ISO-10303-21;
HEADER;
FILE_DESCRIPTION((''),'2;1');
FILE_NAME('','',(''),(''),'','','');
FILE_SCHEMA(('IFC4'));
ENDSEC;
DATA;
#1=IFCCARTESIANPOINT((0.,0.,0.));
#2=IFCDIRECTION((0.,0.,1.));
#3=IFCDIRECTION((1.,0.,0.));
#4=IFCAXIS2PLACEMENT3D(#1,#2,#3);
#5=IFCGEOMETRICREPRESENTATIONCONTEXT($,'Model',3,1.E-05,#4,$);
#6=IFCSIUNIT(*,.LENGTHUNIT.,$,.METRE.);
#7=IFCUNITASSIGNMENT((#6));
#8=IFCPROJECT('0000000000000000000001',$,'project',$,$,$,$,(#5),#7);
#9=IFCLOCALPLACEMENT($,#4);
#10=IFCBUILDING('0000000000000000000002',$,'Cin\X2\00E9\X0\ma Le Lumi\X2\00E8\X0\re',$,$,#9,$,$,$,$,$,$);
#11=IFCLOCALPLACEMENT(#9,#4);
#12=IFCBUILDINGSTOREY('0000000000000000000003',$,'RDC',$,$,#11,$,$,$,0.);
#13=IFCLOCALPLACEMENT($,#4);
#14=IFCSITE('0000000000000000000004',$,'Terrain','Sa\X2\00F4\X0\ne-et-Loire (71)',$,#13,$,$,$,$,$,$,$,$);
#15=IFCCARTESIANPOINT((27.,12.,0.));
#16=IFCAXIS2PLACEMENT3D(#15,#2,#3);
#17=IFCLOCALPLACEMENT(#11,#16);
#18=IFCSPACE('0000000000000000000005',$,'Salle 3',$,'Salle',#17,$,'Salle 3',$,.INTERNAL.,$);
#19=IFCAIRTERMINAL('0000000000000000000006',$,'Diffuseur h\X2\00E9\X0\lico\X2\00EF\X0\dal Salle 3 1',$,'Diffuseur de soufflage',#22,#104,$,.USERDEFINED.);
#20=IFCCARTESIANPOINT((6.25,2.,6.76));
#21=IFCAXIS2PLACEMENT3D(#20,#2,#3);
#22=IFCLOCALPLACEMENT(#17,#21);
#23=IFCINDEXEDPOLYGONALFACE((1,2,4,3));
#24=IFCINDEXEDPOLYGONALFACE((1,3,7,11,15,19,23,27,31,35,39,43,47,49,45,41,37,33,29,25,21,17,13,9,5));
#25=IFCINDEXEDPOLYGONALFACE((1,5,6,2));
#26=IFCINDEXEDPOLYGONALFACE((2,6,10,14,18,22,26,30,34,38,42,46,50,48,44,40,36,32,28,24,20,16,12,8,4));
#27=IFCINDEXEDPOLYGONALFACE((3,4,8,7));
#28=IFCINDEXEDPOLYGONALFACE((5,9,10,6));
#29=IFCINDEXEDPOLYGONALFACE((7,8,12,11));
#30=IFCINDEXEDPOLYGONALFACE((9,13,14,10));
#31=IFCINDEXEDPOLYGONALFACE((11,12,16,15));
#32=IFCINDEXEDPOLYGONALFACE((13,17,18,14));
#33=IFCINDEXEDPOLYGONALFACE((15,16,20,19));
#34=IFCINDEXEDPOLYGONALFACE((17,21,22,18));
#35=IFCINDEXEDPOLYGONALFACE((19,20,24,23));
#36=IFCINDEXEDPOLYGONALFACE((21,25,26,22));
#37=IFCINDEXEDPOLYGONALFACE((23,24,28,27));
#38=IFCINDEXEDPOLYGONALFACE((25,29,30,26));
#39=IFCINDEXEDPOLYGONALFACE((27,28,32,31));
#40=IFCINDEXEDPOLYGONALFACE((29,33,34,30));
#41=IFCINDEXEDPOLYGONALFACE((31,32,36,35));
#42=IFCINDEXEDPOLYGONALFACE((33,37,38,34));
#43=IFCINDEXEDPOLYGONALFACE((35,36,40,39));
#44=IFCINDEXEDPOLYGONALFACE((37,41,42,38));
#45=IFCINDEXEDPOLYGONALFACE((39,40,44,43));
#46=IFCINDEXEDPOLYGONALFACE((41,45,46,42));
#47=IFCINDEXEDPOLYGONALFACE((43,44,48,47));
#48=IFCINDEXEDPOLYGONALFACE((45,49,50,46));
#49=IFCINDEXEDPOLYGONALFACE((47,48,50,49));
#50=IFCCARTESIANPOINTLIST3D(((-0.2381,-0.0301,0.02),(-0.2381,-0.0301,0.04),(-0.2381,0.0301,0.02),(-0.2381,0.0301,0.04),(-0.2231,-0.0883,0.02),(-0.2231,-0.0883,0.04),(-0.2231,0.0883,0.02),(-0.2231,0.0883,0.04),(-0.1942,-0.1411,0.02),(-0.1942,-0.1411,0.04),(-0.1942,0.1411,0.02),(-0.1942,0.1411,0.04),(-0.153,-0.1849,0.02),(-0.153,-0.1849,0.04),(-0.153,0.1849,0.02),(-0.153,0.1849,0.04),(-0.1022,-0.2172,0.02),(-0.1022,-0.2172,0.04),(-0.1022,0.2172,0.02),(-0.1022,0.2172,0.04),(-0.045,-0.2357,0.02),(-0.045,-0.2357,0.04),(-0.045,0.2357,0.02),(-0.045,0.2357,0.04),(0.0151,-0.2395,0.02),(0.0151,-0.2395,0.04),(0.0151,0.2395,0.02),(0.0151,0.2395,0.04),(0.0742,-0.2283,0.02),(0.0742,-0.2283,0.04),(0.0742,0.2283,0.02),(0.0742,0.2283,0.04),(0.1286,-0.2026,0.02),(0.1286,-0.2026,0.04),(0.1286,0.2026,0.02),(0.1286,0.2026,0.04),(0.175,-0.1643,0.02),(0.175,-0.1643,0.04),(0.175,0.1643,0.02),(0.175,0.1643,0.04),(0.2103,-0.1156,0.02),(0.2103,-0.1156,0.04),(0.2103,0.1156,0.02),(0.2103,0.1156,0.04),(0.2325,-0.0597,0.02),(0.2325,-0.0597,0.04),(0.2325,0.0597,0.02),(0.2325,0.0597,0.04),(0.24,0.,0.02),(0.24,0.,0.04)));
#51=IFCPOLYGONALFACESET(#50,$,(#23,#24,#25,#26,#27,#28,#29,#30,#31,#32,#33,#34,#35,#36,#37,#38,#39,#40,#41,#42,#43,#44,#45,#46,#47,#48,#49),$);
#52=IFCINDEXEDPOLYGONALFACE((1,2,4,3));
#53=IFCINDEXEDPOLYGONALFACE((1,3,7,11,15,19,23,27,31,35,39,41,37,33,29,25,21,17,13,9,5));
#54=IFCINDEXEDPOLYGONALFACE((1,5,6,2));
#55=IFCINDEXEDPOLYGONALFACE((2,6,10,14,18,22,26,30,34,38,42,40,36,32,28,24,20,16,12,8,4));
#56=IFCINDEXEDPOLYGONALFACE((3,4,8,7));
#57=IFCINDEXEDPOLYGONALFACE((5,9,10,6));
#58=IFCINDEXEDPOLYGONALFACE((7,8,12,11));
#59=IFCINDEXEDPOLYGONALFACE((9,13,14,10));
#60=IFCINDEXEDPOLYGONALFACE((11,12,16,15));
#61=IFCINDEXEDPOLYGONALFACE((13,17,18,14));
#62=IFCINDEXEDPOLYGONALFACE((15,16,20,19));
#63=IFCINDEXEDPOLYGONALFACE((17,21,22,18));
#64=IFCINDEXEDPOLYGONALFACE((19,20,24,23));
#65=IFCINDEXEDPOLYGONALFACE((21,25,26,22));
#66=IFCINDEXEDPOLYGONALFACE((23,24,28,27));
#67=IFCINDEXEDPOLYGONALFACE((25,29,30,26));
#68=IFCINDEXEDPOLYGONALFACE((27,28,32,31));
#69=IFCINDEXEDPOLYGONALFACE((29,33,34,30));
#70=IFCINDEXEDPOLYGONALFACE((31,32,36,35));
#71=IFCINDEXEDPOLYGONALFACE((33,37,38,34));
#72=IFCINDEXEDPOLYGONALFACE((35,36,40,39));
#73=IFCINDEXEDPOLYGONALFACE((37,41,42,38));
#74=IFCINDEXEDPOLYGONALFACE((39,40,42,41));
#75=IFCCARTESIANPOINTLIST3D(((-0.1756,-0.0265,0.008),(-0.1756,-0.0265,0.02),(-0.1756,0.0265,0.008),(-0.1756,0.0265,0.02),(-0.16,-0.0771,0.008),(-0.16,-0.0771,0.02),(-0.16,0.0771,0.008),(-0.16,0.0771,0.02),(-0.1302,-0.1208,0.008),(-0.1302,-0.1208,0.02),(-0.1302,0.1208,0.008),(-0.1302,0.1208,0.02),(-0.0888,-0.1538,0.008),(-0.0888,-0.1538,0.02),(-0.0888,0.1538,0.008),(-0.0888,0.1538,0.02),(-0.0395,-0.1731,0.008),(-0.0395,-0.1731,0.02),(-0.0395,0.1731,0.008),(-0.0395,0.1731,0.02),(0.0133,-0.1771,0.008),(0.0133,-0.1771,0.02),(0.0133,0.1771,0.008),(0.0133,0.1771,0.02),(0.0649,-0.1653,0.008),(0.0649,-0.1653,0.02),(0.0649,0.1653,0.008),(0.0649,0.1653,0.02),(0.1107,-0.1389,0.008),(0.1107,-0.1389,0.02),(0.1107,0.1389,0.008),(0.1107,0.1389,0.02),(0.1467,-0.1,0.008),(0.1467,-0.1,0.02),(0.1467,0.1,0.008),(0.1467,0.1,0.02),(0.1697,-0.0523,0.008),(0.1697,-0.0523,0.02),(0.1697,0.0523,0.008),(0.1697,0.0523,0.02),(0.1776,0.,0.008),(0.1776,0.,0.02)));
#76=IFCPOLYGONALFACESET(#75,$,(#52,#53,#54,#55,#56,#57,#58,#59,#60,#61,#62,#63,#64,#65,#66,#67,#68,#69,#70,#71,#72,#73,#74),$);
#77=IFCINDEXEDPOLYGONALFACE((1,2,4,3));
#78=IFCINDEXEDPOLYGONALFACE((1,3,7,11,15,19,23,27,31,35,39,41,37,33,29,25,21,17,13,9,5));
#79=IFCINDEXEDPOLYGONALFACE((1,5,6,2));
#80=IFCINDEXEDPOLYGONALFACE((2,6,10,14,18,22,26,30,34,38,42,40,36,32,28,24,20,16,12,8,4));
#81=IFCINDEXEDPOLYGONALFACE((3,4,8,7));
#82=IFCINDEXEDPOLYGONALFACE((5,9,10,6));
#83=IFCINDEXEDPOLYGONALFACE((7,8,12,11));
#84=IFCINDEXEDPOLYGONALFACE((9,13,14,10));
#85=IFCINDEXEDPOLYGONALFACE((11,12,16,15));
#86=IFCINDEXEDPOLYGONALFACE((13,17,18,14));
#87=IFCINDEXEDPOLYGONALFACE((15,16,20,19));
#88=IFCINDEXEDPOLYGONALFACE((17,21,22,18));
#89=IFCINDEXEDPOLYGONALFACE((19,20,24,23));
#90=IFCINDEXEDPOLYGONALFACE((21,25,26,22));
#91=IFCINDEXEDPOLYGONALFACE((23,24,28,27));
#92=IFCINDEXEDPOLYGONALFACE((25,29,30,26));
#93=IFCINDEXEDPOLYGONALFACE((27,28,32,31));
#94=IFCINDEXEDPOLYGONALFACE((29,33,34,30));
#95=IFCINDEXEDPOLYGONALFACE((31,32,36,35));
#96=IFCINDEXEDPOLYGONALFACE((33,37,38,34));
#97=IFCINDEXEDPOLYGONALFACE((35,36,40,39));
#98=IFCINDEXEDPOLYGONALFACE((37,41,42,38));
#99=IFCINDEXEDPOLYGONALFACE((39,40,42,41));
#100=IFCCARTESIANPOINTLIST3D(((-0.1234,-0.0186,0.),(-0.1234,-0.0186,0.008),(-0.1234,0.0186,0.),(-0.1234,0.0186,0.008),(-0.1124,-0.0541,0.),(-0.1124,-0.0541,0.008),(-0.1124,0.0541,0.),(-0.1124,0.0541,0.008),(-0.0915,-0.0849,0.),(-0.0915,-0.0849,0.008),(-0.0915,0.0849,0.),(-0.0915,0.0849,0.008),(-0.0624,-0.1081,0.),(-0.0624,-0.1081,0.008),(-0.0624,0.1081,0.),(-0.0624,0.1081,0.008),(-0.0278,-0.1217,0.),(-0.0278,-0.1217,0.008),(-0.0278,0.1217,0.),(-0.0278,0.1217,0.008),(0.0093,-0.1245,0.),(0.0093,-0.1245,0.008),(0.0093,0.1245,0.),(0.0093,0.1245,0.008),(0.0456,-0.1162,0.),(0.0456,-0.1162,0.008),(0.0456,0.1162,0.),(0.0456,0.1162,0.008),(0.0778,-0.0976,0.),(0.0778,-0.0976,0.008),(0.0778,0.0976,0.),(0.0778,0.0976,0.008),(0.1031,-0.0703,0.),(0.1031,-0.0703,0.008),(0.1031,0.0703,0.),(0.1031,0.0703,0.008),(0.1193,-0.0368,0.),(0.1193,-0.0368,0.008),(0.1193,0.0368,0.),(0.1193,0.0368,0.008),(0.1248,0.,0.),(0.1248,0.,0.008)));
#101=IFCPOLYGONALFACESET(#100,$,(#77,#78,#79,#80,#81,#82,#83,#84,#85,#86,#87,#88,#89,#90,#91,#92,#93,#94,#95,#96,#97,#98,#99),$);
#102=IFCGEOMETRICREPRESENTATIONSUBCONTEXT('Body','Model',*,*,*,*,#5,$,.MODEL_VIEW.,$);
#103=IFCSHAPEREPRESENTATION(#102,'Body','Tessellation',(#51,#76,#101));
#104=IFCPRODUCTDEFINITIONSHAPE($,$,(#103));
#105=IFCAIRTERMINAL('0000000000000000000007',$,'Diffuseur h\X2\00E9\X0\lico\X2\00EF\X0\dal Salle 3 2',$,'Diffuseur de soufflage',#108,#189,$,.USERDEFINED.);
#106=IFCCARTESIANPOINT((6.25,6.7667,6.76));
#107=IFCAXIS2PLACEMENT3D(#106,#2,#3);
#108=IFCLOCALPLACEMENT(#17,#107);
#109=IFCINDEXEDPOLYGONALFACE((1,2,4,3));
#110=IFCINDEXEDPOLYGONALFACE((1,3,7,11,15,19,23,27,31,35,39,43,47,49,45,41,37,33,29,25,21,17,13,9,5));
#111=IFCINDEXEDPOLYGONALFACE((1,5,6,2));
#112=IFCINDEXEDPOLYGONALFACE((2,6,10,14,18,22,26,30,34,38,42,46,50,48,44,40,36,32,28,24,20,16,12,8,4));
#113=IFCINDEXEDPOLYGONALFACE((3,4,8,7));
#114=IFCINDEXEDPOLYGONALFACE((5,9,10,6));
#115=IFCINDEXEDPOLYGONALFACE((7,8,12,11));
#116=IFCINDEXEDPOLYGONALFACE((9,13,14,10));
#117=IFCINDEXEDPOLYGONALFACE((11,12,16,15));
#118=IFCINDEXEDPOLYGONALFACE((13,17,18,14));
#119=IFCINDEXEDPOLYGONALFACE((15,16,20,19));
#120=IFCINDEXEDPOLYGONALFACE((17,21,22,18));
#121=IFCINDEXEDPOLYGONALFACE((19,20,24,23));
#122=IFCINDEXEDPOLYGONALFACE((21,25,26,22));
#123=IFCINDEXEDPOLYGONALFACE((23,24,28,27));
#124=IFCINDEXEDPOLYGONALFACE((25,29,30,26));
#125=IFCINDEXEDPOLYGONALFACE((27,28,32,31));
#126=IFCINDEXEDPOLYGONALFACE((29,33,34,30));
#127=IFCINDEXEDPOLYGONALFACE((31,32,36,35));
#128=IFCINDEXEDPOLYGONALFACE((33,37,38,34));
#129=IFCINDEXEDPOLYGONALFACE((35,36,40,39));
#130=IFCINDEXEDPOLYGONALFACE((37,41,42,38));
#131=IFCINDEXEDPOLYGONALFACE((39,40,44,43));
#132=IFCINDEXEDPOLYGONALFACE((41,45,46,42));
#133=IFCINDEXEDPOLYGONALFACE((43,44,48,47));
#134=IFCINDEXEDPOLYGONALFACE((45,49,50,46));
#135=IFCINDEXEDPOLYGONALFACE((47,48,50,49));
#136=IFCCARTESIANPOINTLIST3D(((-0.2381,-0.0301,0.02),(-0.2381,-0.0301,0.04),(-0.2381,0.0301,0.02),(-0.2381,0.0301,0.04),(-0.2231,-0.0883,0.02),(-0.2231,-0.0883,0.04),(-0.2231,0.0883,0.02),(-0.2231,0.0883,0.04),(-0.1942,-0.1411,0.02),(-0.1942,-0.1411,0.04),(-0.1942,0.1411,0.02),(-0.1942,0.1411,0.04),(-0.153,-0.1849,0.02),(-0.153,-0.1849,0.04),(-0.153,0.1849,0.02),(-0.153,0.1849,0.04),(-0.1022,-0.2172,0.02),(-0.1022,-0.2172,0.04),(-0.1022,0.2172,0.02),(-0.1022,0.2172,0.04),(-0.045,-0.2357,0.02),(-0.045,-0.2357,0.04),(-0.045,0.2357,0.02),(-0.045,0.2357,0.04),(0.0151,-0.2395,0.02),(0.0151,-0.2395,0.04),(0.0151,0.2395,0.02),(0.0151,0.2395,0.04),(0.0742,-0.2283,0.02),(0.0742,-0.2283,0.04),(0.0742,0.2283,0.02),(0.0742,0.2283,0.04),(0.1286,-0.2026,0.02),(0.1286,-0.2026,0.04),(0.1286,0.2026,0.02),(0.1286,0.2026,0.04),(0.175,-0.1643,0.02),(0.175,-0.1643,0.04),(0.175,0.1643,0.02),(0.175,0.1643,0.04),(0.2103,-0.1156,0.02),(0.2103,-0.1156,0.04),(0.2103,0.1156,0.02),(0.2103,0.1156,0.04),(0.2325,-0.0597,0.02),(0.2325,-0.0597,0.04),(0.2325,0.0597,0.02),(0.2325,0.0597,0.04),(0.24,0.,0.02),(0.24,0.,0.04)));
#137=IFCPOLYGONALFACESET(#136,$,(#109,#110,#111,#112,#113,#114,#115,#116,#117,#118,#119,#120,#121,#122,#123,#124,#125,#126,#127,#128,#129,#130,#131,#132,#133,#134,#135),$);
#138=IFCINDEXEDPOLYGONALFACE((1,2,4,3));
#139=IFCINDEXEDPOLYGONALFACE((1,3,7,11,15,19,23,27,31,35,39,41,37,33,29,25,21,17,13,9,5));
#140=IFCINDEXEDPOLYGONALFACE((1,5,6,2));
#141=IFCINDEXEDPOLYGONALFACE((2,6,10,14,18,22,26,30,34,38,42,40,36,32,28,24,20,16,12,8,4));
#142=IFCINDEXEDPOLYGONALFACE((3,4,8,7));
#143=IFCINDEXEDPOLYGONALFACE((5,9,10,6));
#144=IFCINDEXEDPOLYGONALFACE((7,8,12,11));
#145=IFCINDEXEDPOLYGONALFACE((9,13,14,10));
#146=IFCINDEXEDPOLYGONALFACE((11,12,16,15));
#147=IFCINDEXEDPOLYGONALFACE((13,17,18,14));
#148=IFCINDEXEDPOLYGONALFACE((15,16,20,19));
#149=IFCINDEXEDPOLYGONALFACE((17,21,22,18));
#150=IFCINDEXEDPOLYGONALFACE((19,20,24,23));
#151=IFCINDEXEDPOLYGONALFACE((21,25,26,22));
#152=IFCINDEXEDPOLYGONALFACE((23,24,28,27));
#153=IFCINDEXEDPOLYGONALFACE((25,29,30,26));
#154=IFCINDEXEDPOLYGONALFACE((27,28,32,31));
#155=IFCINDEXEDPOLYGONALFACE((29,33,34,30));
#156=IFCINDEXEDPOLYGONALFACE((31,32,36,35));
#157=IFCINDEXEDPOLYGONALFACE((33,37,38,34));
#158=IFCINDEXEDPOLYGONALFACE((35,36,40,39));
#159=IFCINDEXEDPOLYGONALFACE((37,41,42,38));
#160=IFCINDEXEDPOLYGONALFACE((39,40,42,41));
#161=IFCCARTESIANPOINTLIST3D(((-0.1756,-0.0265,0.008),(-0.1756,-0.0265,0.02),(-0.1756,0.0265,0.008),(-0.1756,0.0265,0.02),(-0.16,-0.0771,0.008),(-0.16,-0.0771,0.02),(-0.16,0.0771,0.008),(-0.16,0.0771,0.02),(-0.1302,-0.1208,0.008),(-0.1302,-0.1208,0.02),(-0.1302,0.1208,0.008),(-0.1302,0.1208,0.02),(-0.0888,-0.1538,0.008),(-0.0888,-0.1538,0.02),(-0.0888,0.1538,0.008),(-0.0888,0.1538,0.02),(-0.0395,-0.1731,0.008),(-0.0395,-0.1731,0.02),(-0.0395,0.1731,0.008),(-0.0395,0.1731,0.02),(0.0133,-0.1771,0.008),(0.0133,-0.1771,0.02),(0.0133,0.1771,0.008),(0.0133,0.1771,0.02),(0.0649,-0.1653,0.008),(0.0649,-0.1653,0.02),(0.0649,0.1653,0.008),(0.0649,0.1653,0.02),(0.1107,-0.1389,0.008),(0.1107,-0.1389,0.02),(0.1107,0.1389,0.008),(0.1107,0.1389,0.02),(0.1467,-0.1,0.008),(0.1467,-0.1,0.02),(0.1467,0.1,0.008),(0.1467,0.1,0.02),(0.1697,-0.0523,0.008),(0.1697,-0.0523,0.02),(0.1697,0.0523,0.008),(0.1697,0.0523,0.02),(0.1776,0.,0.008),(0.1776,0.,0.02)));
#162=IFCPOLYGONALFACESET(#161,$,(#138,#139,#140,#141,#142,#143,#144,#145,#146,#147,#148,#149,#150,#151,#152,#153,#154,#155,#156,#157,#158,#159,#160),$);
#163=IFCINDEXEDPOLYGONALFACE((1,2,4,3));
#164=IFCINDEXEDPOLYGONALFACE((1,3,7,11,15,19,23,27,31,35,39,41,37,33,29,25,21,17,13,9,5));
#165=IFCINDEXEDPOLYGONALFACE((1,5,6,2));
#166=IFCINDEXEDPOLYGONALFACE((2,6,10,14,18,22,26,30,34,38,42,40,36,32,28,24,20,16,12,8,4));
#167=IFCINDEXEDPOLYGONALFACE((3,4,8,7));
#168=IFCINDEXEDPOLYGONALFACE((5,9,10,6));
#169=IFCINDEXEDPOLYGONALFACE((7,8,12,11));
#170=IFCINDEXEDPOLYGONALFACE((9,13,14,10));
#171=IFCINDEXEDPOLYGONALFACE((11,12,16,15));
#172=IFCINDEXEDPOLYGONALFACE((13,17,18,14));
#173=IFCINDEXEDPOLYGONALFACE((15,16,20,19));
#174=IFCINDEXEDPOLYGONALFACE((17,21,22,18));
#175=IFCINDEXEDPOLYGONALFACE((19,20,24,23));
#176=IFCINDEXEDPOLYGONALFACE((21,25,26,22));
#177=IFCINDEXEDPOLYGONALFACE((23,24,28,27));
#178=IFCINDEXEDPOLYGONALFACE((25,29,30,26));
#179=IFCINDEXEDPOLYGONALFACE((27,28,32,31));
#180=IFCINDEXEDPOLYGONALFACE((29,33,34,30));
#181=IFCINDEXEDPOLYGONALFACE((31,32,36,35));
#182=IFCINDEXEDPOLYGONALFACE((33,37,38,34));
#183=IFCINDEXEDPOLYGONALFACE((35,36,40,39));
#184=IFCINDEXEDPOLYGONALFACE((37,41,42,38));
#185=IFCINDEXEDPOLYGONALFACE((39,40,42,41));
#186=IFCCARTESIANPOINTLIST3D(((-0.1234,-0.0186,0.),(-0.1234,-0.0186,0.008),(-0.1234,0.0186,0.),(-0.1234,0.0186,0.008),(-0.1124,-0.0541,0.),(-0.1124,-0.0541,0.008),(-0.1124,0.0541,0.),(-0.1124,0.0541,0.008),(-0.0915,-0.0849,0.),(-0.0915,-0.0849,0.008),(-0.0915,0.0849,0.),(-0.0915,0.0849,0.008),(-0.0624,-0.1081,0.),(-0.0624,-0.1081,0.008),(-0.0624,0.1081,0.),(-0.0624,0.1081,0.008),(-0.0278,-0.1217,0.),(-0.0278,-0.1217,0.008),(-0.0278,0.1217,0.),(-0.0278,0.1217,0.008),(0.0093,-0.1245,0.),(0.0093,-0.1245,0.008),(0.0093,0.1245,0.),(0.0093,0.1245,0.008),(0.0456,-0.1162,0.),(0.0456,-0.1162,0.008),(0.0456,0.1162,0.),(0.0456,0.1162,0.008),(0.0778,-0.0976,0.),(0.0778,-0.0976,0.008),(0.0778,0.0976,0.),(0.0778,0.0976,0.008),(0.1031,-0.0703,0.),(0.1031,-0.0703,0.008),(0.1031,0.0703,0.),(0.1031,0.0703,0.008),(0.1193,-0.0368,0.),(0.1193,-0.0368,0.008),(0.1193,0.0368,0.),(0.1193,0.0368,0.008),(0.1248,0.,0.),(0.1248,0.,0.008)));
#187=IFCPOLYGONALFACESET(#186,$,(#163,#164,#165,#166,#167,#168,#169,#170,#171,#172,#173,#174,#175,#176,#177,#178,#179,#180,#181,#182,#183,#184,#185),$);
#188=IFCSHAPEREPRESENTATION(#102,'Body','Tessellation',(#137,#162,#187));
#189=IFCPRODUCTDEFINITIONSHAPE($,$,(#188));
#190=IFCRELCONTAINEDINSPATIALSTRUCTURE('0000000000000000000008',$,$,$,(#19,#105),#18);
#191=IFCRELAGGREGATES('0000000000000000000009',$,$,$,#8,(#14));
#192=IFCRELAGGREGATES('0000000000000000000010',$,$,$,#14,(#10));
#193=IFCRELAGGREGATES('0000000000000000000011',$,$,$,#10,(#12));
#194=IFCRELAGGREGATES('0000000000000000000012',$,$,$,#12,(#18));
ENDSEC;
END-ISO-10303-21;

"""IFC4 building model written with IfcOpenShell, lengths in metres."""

from ifc_helpers import new_model, si_unit, frame, origin_with_axes, place, context, subcontext, project, spatial, circle, extrude, element, save


model = new_model("IFC4")

# Units and contexts
model_context = context("Model", 3, precision=1e-05, world=origin_with_axes())
body_context = subcontext(model_context, "Body", "Model", "MODEL_VIEW")
ifc_project = project(units=[si_unit("LENGTHUNIT", "METRE")], contexts=[model_context])

# Site, building, storey
site_placement = place(None, origin_with_axes())
site = spatial("IfcSite", under=ifc_project, at=site_placement, Name="Terrain", Description="Saône-et-Loire (71)")
building_placement = place(None, origin_with_axes())
building = spatial("IfcBuilding", under=site, at=building_placement, Name="Cinéma Le Lumière")
storey_placement = place(building_placement, origin_with_axes())
storey = spatial("IfcBuildingStorey", under=building, at=storey_placement, Name="RDC", Elevation=0.0)

# Shared definitions
space_1_placement = place(storey_placement, frame((27.0, 12.0, 0.0), z_axis=(0.0, 0.0, 1.0), x_axis=(1.0, 0.0, 0.0)))
space_1 = spatial("IfcSpace", under=storey, at=space_1_placement, Name="Salle 3", ObjectType="Salle", LongName="Salle 3", PredefinedType="INTERNAL")

# Air terminals
for number, where, z_axis, x_axis, name in (
    (1, (6.25, 2.0, 6.76), (0.0, 0.0, 1.0), (1.0, 0.0, 0.0), "Diffuseur hélicoïdal Salle 3 1"),
    (2, (6.25, 6.7667, 6.76), (0.0, 0.0, 1.0), (1.0, 0.0, 0.0), "Diffuseur hélicoïdal Salle 3 2"),
):
    element("IfcAirTerminal", number, at=place(space_1_placement, frame(where, z_axis=z_axis, x_axis=x_axis)), inside=space_1, Name=name, ObjectType="Diffuseur de soufflage", PredefinedType="USERDEFINED", context=body_context, shape_type="SweptSolid", body=[
        extrude(circle(Radius=0.24), frame((0.0, 0.0, 0.02), z_axis=(0.0, 0.0, 1.0), x_axis=(1.0, 0.0, 0.0)), (0.0, 0.0, 1.0), 0.02),
        extrude(circle(Radius=0.1776), frame((0.0, 0.0, 0.008), z_axis=(0.0, 0.0, 1.0), x_axis=(1.0, 0.0, 0.0)), (0.0, 0.0, 1.0), 0.012),
        extrude(circle(Radius=0.1248), origin_with_axes(), (0.0, 0.0, 1.0), 0.008),
    ])

save(model, "model.ifc")
